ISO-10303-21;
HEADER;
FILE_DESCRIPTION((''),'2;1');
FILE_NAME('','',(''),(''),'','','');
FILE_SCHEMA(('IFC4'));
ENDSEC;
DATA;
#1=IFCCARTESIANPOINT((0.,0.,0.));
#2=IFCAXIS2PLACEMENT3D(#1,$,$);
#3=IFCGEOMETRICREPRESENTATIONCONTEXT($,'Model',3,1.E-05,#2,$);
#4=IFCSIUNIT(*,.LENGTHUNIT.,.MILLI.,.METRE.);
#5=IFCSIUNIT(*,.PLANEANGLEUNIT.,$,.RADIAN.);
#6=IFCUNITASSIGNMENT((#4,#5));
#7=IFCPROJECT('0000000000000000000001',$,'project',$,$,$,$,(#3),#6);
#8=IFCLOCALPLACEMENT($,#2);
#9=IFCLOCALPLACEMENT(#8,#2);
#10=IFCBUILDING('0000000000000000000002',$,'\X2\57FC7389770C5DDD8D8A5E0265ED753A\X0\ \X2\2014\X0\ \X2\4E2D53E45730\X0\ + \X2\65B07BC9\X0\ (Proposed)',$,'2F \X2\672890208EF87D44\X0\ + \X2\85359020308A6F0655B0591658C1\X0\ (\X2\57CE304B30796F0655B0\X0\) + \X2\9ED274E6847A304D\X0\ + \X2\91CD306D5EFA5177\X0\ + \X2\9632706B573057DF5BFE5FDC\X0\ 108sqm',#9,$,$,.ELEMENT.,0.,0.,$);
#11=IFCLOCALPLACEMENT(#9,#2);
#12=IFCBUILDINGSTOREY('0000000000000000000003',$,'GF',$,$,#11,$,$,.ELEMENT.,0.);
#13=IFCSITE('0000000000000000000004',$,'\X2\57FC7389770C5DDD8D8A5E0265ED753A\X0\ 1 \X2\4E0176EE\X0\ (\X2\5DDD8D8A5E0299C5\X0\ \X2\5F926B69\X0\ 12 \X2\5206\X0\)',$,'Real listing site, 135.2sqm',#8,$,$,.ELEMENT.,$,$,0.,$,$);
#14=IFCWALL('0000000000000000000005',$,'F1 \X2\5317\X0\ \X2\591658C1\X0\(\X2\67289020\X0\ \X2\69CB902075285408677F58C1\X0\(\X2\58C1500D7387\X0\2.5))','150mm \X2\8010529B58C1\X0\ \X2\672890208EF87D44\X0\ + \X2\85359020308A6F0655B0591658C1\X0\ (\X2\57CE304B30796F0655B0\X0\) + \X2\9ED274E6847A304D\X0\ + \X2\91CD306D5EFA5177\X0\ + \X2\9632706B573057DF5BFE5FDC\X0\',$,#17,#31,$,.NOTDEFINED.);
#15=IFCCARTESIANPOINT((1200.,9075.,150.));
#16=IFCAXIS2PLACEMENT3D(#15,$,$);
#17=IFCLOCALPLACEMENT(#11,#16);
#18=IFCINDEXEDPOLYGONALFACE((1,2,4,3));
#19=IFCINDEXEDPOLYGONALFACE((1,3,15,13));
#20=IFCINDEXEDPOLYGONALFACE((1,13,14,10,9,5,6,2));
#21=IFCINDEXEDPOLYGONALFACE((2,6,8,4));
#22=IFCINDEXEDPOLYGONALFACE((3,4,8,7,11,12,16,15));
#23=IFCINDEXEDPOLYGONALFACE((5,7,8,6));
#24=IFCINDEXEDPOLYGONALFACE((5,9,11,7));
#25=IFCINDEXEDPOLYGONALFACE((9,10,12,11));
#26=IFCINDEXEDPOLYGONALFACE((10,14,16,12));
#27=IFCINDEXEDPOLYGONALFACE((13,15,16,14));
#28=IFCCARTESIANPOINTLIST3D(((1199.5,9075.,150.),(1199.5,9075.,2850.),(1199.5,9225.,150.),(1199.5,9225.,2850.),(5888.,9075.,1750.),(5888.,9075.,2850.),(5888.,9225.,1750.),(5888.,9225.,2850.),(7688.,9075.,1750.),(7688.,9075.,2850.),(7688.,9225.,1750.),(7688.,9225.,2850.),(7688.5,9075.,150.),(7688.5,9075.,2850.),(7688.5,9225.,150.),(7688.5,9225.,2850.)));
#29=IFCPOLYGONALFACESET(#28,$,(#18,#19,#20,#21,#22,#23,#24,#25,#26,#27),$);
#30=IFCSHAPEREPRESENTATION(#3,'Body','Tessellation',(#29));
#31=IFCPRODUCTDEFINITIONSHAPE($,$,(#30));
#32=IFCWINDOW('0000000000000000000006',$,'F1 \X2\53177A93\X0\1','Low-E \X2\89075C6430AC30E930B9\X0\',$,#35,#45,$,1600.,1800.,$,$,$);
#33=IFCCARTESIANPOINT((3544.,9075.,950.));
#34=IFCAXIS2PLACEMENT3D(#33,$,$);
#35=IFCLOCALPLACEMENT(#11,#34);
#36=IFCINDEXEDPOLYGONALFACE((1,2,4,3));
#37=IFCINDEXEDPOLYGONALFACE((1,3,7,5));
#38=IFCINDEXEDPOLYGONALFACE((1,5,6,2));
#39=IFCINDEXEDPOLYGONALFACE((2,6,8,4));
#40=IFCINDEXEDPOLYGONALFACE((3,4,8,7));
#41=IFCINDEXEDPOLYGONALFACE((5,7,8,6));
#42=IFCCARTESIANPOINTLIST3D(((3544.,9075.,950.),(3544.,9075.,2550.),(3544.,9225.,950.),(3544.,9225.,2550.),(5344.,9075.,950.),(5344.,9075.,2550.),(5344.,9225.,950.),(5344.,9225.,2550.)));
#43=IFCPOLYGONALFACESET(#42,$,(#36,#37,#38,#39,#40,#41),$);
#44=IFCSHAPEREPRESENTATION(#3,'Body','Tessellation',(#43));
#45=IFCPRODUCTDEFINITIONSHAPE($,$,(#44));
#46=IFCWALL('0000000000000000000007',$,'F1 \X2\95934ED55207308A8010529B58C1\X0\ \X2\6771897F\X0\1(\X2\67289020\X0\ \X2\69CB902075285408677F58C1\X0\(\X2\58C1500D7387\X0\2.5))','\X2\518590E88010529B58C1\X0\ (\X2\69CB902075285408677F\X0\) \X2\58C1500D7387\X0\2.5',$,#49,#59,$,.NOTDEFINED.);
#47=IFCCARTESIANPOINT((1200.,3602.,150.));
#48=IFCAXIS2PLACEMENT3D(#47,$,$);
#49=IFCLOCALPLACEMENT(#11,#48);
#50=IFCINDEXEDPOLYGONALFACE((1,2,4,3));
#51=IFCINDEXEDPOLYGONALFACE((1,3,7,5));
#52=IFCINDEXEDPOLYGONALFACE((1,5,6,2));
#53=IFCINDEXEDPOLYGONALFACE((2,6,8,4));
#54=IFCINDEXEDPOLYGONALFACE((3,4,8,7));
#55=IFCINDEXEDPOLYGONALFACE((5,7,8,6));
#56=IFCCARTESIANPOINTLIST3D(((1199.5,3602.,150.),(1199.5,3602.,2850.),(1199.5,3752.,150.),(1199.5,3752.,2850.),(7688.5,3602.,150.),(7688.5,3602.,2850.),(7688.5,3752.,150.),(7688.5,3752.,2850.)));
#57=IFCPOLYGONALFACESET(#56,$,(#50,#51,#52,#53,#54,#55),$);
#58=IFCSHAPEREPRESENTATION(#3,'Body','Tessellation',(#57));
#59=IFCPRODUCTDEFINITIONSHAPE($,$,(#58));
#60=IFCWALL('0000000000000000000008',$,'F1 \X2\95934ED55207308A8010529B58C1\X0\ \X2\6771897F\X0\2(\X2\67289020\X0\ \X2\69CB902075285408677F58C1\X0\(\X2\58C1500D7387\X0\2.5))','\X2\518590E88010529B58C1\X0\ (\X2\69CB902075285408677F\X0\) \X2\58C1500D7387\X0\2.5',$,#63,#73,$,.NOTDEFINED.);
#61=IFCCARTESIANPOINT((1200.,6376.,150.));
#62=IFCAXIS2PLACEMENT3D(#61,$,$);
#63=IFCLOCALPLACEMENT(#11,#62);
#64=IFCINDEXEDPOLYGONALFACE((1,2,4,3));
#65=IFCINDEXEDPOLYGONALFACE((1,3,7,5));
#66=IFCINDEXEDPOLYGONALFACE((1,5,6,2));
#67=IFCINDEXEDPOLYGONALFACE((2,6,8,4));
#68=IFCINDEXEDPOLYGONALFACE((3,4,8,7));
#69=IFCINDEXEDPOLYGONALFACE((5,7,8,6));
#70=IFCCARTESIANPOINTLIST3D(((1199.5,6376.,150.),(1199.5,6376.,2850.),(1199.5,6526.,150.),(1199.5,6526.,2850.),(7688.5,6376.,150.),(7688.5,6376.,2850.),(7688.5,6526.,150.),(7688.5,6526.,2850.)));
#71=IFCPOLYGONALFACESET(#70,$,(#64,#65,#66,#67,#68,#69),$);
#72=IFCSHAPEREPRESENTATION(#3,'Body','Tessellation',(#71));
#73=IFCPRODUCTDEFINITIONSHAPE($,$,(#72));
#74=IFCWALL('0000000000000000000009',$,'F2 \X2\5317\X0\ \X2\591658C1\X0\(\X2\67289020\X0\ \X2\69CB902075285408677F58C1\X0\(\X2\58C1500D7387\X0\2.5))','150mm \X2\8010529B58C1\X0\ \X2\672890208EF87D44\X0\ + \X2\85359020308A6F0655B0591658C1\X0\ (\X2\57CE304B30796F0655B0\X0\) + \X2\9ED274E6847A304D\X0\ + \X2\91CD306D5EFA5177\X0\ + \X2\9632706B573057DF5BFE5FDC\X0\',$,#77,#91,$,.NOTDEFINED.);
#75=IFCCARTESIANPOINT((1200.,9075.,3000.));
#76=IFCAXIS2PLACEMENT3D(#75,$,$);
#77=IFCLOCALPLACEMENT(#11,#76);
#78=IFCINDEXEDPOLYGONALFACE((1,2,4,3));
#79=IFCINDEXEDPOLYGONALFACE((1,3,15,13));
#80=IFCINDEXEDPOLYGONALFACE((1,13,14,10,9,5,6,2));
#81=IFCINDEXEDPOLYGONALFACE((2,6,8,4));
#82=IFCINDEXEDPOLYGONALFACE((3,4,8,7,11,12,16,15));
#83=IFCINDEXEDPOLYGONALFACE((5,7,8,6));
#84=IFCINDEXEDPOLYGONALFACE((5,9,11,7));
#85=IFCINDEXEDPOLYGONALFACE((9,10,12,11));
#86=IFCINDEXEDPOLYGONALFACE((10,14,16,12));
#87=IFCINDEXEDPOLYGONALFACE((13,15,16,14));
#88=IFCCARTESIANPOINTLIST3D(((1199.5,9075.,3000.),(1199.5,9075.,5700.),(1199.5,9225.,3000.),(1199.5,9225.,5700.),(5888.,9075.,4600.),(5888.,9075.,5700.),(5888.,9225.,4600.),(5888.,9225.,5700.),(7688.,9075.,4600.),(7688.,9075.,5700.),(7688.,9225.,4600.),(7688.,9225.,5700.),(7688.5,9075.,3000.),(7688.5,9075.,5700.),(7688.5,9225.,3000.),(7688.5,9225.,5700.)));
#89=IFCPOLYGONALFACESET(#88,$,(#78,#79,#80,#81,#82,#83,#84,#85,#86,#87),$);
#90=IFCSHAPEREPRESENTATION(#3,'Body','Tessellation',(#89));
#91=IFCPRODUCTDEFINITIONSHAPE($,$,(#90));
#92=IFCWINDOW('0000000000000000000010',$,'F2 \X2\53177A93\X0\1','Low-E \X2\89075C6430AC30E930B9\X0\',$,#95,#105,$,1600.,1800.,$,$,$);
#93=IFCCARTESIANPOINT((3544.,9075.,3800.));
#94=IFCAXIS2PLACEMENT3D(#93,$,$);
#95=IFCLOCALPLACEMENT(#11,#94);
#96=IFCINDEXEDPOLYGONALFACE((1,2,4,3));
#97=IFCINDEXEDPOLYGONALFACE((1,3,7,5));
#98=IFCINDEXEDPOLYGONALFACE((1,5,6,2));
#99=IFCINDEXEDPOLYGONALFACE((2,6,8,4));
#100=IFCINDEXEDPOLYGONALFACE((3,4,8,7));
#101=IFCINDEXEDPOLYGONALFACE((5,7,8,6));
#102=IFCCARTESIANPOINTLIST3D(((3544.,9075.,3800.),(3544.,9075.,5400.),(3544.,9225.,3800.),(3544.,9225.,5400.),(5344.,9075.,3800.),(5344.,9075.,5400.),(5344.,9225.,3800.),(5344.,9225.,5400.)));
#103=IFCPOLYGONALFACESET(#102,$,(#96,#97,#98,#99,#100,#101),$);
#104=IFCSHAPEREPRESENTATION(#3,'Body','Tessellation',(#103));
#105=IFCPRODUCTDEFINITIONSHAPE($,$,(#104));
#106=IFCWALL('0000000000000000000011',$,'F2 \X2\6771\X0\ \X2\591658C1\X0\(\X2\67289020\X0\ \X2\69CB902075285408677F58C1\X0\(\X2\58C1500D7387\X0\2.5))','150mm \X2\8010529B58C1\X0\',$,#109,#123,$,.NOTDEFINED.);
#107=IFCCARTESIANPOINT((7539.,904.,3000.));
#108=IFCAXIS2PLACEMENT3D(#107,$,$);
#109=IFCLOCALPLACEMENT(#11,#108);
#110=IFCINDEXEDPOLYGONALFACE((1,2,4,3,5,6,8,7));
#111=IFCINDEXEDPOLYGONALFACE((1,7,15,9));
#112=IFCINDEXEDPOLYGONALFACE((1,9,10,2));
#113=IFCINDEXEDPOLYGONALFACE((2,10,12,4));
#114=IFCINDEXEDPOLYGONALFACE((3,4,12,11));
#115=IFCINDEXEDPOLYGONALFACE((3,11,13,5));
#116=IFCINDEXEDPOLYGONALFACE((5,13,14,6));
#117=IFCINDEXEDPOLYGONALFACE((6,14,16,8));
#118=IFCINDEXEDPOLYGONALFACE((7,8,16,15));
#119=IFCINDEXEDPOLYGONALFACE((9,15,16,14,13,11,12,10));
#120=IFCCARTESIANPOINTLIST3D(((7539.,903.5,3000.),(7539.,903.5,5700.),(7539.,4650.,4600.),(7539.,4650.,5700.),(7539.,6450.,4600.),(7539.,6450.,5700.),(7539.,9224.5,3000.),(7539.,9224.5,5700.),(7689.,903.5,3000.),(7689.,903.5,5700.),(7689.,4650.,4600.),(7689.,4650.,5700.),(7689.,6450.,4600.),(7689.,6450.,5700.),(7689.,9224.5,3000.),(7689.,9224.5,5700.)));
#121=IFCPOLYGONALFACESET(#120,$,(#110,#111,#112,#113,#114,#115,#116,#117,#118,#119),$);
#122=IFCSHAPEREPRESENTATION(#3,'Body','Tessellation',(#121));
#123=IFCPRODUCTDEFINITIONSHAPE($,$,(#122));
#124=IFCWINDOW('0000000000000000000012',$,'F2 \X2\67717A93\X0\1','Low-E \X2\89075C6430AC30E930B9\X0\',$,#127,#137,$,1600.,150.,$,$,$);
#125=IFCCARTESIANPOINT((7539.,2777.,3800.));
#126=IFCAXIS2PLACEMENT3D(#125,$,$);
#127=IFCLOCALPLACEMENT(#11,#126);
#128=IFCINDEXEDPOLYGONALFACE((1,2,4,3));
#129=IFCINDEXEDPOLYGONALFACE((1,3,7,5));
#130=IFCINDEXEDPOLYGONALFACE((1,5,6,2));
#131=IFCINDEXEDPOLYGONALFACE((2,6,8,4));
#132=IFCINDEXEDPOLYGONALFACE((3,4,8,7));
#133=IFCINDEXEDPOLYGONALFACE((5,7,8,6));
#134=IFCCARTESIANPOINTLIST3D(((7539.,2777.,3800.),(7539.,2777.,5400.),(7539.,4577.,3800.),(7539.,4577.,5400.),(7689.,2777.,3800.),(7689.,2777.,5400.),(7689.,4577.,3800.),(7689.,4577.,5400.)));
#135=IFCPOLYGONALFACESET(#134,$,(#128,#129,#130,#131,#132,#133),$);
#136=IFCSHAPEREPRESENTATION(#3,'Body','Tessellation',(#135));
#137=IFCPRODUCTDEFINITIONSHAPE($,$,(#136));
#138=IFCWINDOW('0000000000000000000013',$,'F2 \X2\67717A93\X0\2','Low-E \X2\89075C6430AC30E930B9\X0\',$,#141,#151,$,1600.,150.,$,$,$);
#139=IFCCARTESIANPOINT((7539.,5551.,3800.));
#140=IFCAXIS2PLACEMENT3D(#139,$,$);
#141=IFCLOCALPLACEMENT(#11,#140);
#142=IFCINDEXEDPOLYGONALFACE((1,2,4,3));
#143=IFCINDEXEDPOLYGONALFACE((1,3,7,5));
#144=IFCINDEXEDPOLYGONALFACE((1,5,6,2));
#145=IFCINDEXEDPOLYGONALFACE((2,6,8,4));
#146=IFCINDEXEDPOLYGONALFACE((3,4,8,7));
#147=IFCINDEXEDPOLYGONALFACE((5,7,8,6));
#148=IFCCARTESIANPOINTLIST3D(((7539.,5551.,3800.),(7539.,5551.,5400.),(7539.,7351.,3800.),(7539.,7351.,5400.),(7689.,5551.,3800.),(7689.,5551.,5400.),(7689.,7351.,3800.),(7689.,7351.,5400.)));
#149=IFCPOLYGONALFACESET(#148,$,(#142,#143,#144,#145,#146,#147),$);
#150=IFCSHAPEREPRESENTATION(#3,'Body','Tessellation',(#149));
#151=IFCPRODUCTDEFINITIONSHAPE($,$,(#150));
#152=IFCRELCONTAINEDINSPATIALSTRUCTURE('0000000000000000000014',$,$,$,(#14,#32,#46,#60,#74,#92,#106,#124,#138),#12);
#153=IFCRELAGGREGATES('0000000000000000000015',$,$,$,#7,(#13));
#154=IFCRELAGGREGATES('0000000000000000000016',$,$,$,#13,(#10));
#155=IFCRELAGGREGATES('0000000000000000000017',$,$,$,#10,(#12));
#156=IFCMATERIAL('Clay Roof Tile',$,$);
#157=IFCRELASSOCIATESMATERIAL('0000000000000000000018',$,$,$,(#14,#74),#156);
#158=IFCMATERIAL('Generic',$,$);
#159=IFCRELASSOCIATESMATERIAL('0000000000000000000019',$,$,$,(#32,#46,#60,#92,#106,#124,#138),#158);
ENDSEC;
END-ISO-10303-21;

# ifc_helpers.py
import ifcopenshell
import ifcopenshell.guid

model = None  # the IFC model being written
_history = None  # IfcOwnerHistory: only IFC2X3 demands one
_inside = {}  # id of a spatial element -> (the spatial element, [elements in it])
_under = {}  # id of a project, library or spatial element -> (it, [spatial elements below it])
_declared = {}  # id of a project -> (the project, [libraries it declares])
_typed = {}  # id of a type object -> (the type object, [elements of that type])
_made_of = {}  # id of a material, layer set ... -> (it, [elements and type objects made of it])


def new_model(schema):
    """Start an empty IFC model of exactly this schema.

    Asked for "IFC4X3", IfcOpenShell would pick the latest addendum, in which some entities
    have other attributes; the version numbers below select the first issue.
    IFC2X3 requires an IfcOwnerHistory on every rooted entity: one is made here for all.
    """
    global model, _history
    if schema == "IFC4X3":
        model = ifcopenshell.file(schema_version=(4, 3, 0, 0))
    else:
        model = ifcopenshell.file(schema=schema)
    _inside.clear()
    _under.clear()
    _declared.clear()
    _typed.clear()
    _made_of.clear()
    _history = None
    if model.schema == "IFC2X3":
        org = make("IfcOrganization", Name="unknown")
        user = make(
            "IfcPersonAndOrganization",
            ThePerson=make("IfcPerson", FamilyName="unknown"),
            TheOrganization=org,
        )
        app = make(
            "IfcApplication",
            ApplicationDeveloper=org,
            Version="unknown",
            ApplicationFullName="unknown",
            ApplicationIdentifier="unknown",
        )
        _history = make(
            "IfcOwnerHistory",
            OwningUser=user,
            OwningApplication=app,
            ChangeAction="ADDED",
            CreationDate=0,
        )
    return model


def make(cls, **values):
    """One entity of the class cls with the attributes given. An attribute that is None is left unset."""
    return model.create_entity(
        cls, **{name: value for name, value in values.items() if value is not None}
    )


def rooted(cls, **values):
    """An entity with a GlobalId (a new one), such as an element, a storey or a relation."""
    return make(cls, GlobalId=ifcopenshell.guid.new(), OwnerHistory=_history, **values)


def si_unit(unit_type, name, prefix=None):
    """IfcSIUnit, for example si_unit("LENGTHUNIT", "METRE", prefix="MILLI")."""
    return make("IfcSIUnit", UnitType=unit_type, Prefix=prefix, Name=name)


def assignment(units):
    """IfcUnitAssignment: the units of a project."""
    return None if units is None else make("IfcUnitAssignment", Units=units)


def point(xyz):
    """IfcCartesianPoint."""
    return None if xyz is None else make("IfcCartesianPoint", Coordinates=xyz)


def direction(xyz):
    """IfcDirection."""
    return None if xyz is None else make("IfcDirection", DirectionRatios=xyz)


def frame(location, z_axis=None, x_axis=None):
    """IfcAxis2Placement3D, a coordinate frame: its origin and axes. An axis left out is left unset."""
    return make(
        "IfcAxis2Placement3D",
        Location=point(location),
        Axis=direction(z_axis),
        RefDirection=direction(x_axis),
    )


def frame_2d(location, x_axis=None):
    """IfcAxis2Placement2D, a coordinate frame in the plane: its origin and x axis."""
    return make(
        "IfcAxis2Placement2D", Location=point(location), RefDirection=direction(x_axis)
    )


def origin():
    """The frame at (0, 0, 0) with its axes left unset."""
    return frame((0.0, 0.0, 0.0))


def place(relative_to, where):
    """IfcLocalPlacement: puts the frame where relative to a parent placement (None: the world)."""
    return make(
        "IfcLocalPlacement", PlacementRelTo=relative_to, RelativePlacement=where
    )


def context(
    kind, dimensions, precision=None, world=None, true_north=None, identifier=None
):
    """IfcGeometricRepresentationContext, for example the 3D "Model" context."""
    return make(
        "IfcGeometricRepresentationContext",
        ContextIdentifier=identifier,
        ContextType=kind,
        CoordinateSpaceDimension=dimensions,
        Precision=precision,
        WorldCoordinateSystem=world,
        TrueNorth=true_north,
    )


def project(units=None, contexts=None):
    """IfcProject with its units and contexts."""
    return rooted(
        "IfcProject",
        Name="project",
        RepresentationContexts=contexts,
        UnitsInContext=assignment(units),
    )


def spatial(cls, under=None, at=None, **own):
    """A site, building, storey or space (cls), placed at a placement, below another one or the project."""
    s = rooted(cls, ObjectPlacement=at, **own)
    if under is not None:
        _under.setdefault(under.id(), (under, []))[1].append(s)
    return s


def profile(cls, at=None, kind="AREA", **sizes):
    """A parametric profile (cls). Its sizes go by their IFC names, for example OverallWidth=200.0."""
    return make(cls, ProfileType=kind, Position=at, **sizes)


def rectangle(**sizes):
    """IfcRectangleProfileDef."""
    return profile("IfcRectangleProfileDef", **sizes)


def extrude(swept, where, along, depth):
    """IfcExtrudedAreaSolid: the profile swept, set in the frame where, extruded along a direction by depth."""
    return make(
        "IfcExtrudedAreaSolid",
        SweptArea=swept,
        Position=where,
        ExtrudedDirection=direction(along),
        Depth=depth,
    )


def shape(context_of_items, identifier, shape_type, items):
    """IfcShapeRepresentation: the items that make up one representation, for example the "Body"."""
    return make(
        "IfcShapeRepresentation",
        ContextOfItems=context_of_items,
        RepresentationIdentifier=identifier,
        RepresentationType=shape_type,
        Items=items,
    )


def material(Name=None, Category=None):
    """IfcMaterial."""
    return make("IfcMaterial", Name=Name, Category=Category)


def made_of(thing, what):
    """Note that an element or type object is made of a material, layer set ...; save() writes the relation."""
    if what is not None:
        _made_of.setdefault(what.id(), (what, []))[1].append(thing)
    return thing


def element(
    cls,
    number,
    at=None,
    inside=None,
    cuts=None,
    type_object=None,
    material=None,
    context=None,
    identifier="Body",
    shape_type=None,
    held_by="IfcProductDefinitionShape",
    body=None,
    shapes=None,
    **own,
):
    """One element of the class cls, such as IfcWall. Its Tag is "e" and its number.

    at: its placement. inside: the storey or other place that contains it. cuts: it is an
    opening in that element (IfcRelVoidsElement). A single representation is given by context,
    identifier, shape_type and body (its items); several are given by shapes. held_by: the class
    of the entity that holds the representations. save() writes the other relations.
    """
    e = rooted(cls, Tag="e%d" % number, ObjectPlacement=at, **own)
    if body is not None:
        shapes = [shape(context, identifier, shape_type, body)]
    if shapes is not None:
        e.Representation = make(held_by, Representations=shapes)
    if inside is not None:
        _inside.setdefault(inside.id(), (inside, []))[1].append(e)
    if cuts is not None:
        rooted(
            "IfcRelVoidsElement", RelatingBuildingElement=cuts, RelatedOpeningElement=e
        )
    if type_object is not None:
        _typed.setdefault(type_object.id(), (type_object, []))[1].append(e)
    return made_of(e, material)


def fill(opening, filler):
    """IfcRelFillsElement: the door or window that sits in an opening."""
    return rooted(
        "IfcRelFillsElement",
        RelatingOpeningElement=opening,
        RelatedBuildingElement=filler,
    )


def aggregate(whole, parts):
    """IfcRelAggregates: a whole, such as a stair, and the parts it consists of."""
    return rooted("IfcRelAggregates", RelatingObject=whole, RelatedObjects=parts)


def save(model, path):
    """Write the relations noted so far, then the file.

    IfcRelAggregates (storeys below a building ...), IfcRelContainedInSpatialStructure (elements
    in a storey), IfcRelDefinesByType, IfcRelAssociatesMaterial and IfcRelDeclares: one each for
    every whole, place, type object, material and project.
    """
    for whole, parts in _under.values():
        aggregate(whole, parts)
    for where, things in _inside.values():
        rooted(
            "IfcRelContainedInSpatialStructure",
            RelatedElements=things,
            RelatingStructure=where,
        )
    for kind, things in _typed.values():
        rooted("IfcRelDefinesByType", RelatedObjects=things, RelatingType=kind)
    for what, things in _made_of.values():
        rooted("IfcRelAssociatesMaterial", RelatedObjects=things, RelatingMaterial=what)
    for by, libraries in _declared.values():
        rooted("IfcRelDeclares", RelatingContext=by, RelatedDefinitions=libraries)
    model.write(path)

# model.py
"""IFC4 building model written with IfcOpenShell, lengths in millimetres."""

from ifc_helpers import new_model, si_unit, frame, frame_2d, origin, place, context, project, spatial, rectangle, extrude, material, element, fill, save


model = new_model("IFC4")

# Units and contexts
model_context = context("Model", 3, precision=1e-05, world=origin())
ifc_project = project(units=[si_unit("LENGTHUNIT", "METRE", prefix="MILLI"), si_unit("PLANEANGLEUNIT", "RADIAN")], contexts=[model_context])

# Site, building, storey
site_placement = place(None, origin())
site = spatial("IfcSite", under=ifc_project, at=site_placement, Name="埼玉県川越市旭町 1 丁目 (川越市駅 徒歩 12 分)", ObjectType="Real listing site, 135.2sqm", CompositionType="ELEMENT", RefElevation=0.0)
building_placement = place(site_placement, origin())
building = spatial("IfcBuilding", under=site, at=building_placement, Name="埼玉県川越市旭町 — 中古地 + 新築 (Proposed)", ObjectType="2F 木造軸組 + 蔵造り漆喰外壁 (城かべ漆喰) + 黒瓦葺き + 重ね建具 + 防火地域対応 108sqm", CompositionType="ELEMENT", ElevationOfRefHeight=0.0, ElevationOfTerrain=0.0)
storey_placement = place(building_placement, origin())
storey = spatial("IfcBuildingStorey", under=building, at=storey_placement, Name="GF", CompositionType="ELEMENT", Elevation=0.0)

# Wall, opening, window
ifc_material_1 = material(Name="Clay Roof Tile")
wall_1_placement = place(storey_placement, frame((1200.0, 9075.0, 150.0)))
wall_1 = element("IfcWall", 1, at=wall_1_placement, inside=storey, material=ifc_material_1, Name="F1 北 外壁(木造 構造用合板壁(壁倍率2.5))", Description="150mm 耐力壁 木造軸組 + 蔵造り漆喰外壁 (城かべ漆喰) + 黒瓦葺き + 重ね建具 + 防火地域対応", PredefinedType="NOTDEFINED", context=model_context, shape_type="SweptSolid", body=[
    extrude(rectangle(XDim=6489.0, YDim=150.0, at=frame_2d((3244.0, 75.0))), frame((1200.0, 9075.0, 150.0)), (0.0, 0.0, 1.0), 2700.0),
])
opening_1_placement = place(storey_placement, frame((3544.0, 9075.0, 950.0)))
opening_1 = element("IfcOpeningElement", 2, at=opening_1_placement, cuts=wall_1, PredefinedType="NOTDEFINED", context=model_context, shape_type="SweptSolid", body=[
    extrude(rectangle(XDim=1800.0, YDim=150.0, at=frame_2d((900.0, 75.0))), frame((3544.0, 9075.0, 950.0)), (0.0, 0.0, 1.0), 1600.0),
])
ifc_material_2 = material(Name="Generic")
window_1_placement = place(storey_placement, frame((3544.0, 9075.0, 950.0)))
window_1 = element("IfcWindow", 3, at=window_1_placement, inside=storey, material=ifc_material_2, Name="F1 北窓1", Description="Low-E 複層ガラス", OverallHeight=1600.0, OverallWidth=1800.0, context=model_context, shape_type="SweptSolid", body=[
    extrude(rectangle(XDim=1800.0, YDim=150.0, at=frame_2d((900.0, 75.0))), frame((3544.0, 9075.0, 950.0)), (0.0, 0.0, 1.0), 1600.0),
])
fill(opening_1, window_1)

# Walls
wall_2_placement = place(storey_placement, frame((1200.0, 3602.0, 150.0)))
element("IfcWall", 4, at=wall_2_placement, inside=storey, material=ifc_material_2, Name="F1 間仕切り耐力壁 東西1(木造 構造用合板壁(壁倍率2.5))", Description="内部耐力壁 (構造用合板) 壁倍率2.5", PredefinedType="NOTDEFINED", context=model_context, shape_type="SweptSolid", body=[
    extrude(rectangle(XDim=6489.0, YDim=150.0, at=frame_2d((3244.0, 75.0))), frame((1200.0, 3602.0, 150.0)), (0.0, 0.0, 1.0), 2700.0),
])
wall_3_placement = place(storey_placement, frame((1200.0, 6376.0, 150.0)))
element("IfcWall", 5, at=wall_3_placement, inside=storey, material=ifc_material_2, Name="F1 間仕切り耐力壁 東西2(木造 構造用合板壁(壁倍率2.5))", Description="内部耐力壁 (構造用合板) 壁倍率2.5", PredefinedType="NOTDEFINED", context=model_context, shape_type="SweptSolid", body=[
    extrude(rectangle(XDim=6489.0, YDim=150.0, at=frame_2d((3244.0, 75.0))), frame((1200.0, 6376.0, 150.0)), (0.0, 0.0, 1.0), 2700.0),
])

# Wall, opening, window
wall_4_placement = place(storey_placement, frame((1200.0, 9075.0, 3000.0)))
wall_4 = element("IfcWall", 6, at=wall_4_placement, inside=storey, material=ifc_material_1, Name="F2 北 外壁(木造 構造用合板壁(壁倍率2.5))", Description="150mm 耐力壁 木造軸組 + 蔵造り漆喰外壁 (城かべ漆喰) + 黒瓦葺き + 重ね建具 + 防火地域対応", PredefinedType="NOTDEFINED", context=model_context, shape_type="SweptSolid", body=[
    extrude(rectangle(XDim=6489.0, YDim=150.0, at=frame_2d((3244.0, 75.0))), frame((1200.0, 9075.0, 3000.0)), (0.0, 0.0, 1.0), 2700.0),
])
opening_2_placement = place(storey_placement, frame((3544.0, 9075.0, 3800.0)))
opening_2 = element("IfcOpeningElement", 7, at=opening_2_placement, cuts=wall_4, PredefinedType="NOTDEFINED", context=model_context, shape_type="SweptSolid", body=[
    extrude(rectangle(XDim=1800.0, YDim=150.0, at=frame_2d((900.0, 75.0))), frame((3544.0, 9075.0, 3800.0)), (0.0, 0.0, 1.0), 1600.0),
])
window_2_placement = place(storey_placement, frame((3544.0, 9075.0, 3800.0)))
window_2 = element("IfcWindow", 8, at=window_2_placement, inside=storey, material=ifc_material_2, Name="F2 北窓1", Description="Low-E 複層ガラス", OverallHeight=1600.0, OverallWidth=1800.0, context=model_context, shape_type="SweptSolid", body=[
    extrude(rectangle(XDim=1800.0, YDim=150.0, at=frame_2d((900.0, 75.0))), frame((3544.0, 9075.0, 3800.0)), (0.0, 0.0, 1.0), 1600.0),
])
fill(opening_2, window_2)

# Wall, openings, windows
wall_5_placement = place(storey_placement, frame((7539.0, 904.0, 3000.0)))
wall_5 = element("IfcWall", 9, at=wall_5_placement, inside=storey, material=ifc_material_2, Name="F2 東 外壁(木造 構造用合板壁(壁倍率2.5))", Description="150mm 耐力壁", PredefinedType="NOTDEFINED", context=model_context, shape_type="SweptSolid", body=[
    extrude(rectangle(XDim=150.0, YDim=8321.0, at=frame_2d((75.0, 4160.0))), frame((7539.0, 904.0, 3000.0)), (0.0, 0.0, 1.0), 2700.0),
])
opening_3_placement = place(storey_placement, frame((7539.0, 2777.0, 3800.0)))
opening_3 = element("IfcOpeningElement", 10, at=opening_3_placement, cuts=wall_5, PredefinedType="NOTDEFINED", context=model_context, shape_type="SweptSolid", body=[
    extrude(rectangle(XDim=150.0, YDim=1800.0, at=frame_2d((75.0, 900.0))), frame((7539.0, 2777.0, 3800.0)), (0.0, 0.0, 1.0), 1600.0),
])
opening_4_placement = place(storey_placement, frame((7539.0, 5551.0, 3800.0)))
opening_4 = element("IfcOpeningElement", 11, at=opening_4_placement, cuts=wall_5, PredefinedType="NOTDEFINED", context=model_context, shape_type="SweptSolid", body=[
    extrude(rectangle(XDim=150.0, YDim=1800.0, at=frame_2d((75.0, 900.0))), frame((7539.0, 5551.0, 3800.0)), (0.0, 0.0, 1.0), 1600.0),
])
window_3_placement = place(storey_placement, frame((7539.0, 2777.0, 3800.0)))
window_3 = element("IfcWindow", 12, at=window_3_placement, inside=storey, material=ifc_material_2, Name="F2 東窓1", Description="Low-E 複層ガラス", OverallHeight=1600.0, OverallWidth=150.0, context=model_context, shape_type="SweptSolid", body=[
    extrude(rectangle(XDim=150.0, YDim=1800.0, at=frame_2d((75.0, 900.0))), frame((7539.0, 2777.0, 3800.0)), (0.0, 0.0, 1.0), 1600.0),
])
fill(opening_3, window_3)
window_4_placement = place(storey_placement, frame((7539.0, 5551.0, 3800.0)))
window_4 = element("IfcWindow", 13, at=window_4_placement, inside=storey, material=ifc_material_2, Name="F2 東窓2", Description="Low-E 複層ガラス", OverallHeight=1600.0, OverallWidth=150.0, context=model_context, shape_type="SweptSolid", body=[
    extrude(rectangle(XDim=150.0, YDim=1800.0, at=frame_2d((75.0, 900.0))), frame((7539.0, 5551.0, 3800.0)), (0.0, 0.0, 1.0), 1600.0),
])
fill(opening_4, window_4)

save(model, "model.ifc")
